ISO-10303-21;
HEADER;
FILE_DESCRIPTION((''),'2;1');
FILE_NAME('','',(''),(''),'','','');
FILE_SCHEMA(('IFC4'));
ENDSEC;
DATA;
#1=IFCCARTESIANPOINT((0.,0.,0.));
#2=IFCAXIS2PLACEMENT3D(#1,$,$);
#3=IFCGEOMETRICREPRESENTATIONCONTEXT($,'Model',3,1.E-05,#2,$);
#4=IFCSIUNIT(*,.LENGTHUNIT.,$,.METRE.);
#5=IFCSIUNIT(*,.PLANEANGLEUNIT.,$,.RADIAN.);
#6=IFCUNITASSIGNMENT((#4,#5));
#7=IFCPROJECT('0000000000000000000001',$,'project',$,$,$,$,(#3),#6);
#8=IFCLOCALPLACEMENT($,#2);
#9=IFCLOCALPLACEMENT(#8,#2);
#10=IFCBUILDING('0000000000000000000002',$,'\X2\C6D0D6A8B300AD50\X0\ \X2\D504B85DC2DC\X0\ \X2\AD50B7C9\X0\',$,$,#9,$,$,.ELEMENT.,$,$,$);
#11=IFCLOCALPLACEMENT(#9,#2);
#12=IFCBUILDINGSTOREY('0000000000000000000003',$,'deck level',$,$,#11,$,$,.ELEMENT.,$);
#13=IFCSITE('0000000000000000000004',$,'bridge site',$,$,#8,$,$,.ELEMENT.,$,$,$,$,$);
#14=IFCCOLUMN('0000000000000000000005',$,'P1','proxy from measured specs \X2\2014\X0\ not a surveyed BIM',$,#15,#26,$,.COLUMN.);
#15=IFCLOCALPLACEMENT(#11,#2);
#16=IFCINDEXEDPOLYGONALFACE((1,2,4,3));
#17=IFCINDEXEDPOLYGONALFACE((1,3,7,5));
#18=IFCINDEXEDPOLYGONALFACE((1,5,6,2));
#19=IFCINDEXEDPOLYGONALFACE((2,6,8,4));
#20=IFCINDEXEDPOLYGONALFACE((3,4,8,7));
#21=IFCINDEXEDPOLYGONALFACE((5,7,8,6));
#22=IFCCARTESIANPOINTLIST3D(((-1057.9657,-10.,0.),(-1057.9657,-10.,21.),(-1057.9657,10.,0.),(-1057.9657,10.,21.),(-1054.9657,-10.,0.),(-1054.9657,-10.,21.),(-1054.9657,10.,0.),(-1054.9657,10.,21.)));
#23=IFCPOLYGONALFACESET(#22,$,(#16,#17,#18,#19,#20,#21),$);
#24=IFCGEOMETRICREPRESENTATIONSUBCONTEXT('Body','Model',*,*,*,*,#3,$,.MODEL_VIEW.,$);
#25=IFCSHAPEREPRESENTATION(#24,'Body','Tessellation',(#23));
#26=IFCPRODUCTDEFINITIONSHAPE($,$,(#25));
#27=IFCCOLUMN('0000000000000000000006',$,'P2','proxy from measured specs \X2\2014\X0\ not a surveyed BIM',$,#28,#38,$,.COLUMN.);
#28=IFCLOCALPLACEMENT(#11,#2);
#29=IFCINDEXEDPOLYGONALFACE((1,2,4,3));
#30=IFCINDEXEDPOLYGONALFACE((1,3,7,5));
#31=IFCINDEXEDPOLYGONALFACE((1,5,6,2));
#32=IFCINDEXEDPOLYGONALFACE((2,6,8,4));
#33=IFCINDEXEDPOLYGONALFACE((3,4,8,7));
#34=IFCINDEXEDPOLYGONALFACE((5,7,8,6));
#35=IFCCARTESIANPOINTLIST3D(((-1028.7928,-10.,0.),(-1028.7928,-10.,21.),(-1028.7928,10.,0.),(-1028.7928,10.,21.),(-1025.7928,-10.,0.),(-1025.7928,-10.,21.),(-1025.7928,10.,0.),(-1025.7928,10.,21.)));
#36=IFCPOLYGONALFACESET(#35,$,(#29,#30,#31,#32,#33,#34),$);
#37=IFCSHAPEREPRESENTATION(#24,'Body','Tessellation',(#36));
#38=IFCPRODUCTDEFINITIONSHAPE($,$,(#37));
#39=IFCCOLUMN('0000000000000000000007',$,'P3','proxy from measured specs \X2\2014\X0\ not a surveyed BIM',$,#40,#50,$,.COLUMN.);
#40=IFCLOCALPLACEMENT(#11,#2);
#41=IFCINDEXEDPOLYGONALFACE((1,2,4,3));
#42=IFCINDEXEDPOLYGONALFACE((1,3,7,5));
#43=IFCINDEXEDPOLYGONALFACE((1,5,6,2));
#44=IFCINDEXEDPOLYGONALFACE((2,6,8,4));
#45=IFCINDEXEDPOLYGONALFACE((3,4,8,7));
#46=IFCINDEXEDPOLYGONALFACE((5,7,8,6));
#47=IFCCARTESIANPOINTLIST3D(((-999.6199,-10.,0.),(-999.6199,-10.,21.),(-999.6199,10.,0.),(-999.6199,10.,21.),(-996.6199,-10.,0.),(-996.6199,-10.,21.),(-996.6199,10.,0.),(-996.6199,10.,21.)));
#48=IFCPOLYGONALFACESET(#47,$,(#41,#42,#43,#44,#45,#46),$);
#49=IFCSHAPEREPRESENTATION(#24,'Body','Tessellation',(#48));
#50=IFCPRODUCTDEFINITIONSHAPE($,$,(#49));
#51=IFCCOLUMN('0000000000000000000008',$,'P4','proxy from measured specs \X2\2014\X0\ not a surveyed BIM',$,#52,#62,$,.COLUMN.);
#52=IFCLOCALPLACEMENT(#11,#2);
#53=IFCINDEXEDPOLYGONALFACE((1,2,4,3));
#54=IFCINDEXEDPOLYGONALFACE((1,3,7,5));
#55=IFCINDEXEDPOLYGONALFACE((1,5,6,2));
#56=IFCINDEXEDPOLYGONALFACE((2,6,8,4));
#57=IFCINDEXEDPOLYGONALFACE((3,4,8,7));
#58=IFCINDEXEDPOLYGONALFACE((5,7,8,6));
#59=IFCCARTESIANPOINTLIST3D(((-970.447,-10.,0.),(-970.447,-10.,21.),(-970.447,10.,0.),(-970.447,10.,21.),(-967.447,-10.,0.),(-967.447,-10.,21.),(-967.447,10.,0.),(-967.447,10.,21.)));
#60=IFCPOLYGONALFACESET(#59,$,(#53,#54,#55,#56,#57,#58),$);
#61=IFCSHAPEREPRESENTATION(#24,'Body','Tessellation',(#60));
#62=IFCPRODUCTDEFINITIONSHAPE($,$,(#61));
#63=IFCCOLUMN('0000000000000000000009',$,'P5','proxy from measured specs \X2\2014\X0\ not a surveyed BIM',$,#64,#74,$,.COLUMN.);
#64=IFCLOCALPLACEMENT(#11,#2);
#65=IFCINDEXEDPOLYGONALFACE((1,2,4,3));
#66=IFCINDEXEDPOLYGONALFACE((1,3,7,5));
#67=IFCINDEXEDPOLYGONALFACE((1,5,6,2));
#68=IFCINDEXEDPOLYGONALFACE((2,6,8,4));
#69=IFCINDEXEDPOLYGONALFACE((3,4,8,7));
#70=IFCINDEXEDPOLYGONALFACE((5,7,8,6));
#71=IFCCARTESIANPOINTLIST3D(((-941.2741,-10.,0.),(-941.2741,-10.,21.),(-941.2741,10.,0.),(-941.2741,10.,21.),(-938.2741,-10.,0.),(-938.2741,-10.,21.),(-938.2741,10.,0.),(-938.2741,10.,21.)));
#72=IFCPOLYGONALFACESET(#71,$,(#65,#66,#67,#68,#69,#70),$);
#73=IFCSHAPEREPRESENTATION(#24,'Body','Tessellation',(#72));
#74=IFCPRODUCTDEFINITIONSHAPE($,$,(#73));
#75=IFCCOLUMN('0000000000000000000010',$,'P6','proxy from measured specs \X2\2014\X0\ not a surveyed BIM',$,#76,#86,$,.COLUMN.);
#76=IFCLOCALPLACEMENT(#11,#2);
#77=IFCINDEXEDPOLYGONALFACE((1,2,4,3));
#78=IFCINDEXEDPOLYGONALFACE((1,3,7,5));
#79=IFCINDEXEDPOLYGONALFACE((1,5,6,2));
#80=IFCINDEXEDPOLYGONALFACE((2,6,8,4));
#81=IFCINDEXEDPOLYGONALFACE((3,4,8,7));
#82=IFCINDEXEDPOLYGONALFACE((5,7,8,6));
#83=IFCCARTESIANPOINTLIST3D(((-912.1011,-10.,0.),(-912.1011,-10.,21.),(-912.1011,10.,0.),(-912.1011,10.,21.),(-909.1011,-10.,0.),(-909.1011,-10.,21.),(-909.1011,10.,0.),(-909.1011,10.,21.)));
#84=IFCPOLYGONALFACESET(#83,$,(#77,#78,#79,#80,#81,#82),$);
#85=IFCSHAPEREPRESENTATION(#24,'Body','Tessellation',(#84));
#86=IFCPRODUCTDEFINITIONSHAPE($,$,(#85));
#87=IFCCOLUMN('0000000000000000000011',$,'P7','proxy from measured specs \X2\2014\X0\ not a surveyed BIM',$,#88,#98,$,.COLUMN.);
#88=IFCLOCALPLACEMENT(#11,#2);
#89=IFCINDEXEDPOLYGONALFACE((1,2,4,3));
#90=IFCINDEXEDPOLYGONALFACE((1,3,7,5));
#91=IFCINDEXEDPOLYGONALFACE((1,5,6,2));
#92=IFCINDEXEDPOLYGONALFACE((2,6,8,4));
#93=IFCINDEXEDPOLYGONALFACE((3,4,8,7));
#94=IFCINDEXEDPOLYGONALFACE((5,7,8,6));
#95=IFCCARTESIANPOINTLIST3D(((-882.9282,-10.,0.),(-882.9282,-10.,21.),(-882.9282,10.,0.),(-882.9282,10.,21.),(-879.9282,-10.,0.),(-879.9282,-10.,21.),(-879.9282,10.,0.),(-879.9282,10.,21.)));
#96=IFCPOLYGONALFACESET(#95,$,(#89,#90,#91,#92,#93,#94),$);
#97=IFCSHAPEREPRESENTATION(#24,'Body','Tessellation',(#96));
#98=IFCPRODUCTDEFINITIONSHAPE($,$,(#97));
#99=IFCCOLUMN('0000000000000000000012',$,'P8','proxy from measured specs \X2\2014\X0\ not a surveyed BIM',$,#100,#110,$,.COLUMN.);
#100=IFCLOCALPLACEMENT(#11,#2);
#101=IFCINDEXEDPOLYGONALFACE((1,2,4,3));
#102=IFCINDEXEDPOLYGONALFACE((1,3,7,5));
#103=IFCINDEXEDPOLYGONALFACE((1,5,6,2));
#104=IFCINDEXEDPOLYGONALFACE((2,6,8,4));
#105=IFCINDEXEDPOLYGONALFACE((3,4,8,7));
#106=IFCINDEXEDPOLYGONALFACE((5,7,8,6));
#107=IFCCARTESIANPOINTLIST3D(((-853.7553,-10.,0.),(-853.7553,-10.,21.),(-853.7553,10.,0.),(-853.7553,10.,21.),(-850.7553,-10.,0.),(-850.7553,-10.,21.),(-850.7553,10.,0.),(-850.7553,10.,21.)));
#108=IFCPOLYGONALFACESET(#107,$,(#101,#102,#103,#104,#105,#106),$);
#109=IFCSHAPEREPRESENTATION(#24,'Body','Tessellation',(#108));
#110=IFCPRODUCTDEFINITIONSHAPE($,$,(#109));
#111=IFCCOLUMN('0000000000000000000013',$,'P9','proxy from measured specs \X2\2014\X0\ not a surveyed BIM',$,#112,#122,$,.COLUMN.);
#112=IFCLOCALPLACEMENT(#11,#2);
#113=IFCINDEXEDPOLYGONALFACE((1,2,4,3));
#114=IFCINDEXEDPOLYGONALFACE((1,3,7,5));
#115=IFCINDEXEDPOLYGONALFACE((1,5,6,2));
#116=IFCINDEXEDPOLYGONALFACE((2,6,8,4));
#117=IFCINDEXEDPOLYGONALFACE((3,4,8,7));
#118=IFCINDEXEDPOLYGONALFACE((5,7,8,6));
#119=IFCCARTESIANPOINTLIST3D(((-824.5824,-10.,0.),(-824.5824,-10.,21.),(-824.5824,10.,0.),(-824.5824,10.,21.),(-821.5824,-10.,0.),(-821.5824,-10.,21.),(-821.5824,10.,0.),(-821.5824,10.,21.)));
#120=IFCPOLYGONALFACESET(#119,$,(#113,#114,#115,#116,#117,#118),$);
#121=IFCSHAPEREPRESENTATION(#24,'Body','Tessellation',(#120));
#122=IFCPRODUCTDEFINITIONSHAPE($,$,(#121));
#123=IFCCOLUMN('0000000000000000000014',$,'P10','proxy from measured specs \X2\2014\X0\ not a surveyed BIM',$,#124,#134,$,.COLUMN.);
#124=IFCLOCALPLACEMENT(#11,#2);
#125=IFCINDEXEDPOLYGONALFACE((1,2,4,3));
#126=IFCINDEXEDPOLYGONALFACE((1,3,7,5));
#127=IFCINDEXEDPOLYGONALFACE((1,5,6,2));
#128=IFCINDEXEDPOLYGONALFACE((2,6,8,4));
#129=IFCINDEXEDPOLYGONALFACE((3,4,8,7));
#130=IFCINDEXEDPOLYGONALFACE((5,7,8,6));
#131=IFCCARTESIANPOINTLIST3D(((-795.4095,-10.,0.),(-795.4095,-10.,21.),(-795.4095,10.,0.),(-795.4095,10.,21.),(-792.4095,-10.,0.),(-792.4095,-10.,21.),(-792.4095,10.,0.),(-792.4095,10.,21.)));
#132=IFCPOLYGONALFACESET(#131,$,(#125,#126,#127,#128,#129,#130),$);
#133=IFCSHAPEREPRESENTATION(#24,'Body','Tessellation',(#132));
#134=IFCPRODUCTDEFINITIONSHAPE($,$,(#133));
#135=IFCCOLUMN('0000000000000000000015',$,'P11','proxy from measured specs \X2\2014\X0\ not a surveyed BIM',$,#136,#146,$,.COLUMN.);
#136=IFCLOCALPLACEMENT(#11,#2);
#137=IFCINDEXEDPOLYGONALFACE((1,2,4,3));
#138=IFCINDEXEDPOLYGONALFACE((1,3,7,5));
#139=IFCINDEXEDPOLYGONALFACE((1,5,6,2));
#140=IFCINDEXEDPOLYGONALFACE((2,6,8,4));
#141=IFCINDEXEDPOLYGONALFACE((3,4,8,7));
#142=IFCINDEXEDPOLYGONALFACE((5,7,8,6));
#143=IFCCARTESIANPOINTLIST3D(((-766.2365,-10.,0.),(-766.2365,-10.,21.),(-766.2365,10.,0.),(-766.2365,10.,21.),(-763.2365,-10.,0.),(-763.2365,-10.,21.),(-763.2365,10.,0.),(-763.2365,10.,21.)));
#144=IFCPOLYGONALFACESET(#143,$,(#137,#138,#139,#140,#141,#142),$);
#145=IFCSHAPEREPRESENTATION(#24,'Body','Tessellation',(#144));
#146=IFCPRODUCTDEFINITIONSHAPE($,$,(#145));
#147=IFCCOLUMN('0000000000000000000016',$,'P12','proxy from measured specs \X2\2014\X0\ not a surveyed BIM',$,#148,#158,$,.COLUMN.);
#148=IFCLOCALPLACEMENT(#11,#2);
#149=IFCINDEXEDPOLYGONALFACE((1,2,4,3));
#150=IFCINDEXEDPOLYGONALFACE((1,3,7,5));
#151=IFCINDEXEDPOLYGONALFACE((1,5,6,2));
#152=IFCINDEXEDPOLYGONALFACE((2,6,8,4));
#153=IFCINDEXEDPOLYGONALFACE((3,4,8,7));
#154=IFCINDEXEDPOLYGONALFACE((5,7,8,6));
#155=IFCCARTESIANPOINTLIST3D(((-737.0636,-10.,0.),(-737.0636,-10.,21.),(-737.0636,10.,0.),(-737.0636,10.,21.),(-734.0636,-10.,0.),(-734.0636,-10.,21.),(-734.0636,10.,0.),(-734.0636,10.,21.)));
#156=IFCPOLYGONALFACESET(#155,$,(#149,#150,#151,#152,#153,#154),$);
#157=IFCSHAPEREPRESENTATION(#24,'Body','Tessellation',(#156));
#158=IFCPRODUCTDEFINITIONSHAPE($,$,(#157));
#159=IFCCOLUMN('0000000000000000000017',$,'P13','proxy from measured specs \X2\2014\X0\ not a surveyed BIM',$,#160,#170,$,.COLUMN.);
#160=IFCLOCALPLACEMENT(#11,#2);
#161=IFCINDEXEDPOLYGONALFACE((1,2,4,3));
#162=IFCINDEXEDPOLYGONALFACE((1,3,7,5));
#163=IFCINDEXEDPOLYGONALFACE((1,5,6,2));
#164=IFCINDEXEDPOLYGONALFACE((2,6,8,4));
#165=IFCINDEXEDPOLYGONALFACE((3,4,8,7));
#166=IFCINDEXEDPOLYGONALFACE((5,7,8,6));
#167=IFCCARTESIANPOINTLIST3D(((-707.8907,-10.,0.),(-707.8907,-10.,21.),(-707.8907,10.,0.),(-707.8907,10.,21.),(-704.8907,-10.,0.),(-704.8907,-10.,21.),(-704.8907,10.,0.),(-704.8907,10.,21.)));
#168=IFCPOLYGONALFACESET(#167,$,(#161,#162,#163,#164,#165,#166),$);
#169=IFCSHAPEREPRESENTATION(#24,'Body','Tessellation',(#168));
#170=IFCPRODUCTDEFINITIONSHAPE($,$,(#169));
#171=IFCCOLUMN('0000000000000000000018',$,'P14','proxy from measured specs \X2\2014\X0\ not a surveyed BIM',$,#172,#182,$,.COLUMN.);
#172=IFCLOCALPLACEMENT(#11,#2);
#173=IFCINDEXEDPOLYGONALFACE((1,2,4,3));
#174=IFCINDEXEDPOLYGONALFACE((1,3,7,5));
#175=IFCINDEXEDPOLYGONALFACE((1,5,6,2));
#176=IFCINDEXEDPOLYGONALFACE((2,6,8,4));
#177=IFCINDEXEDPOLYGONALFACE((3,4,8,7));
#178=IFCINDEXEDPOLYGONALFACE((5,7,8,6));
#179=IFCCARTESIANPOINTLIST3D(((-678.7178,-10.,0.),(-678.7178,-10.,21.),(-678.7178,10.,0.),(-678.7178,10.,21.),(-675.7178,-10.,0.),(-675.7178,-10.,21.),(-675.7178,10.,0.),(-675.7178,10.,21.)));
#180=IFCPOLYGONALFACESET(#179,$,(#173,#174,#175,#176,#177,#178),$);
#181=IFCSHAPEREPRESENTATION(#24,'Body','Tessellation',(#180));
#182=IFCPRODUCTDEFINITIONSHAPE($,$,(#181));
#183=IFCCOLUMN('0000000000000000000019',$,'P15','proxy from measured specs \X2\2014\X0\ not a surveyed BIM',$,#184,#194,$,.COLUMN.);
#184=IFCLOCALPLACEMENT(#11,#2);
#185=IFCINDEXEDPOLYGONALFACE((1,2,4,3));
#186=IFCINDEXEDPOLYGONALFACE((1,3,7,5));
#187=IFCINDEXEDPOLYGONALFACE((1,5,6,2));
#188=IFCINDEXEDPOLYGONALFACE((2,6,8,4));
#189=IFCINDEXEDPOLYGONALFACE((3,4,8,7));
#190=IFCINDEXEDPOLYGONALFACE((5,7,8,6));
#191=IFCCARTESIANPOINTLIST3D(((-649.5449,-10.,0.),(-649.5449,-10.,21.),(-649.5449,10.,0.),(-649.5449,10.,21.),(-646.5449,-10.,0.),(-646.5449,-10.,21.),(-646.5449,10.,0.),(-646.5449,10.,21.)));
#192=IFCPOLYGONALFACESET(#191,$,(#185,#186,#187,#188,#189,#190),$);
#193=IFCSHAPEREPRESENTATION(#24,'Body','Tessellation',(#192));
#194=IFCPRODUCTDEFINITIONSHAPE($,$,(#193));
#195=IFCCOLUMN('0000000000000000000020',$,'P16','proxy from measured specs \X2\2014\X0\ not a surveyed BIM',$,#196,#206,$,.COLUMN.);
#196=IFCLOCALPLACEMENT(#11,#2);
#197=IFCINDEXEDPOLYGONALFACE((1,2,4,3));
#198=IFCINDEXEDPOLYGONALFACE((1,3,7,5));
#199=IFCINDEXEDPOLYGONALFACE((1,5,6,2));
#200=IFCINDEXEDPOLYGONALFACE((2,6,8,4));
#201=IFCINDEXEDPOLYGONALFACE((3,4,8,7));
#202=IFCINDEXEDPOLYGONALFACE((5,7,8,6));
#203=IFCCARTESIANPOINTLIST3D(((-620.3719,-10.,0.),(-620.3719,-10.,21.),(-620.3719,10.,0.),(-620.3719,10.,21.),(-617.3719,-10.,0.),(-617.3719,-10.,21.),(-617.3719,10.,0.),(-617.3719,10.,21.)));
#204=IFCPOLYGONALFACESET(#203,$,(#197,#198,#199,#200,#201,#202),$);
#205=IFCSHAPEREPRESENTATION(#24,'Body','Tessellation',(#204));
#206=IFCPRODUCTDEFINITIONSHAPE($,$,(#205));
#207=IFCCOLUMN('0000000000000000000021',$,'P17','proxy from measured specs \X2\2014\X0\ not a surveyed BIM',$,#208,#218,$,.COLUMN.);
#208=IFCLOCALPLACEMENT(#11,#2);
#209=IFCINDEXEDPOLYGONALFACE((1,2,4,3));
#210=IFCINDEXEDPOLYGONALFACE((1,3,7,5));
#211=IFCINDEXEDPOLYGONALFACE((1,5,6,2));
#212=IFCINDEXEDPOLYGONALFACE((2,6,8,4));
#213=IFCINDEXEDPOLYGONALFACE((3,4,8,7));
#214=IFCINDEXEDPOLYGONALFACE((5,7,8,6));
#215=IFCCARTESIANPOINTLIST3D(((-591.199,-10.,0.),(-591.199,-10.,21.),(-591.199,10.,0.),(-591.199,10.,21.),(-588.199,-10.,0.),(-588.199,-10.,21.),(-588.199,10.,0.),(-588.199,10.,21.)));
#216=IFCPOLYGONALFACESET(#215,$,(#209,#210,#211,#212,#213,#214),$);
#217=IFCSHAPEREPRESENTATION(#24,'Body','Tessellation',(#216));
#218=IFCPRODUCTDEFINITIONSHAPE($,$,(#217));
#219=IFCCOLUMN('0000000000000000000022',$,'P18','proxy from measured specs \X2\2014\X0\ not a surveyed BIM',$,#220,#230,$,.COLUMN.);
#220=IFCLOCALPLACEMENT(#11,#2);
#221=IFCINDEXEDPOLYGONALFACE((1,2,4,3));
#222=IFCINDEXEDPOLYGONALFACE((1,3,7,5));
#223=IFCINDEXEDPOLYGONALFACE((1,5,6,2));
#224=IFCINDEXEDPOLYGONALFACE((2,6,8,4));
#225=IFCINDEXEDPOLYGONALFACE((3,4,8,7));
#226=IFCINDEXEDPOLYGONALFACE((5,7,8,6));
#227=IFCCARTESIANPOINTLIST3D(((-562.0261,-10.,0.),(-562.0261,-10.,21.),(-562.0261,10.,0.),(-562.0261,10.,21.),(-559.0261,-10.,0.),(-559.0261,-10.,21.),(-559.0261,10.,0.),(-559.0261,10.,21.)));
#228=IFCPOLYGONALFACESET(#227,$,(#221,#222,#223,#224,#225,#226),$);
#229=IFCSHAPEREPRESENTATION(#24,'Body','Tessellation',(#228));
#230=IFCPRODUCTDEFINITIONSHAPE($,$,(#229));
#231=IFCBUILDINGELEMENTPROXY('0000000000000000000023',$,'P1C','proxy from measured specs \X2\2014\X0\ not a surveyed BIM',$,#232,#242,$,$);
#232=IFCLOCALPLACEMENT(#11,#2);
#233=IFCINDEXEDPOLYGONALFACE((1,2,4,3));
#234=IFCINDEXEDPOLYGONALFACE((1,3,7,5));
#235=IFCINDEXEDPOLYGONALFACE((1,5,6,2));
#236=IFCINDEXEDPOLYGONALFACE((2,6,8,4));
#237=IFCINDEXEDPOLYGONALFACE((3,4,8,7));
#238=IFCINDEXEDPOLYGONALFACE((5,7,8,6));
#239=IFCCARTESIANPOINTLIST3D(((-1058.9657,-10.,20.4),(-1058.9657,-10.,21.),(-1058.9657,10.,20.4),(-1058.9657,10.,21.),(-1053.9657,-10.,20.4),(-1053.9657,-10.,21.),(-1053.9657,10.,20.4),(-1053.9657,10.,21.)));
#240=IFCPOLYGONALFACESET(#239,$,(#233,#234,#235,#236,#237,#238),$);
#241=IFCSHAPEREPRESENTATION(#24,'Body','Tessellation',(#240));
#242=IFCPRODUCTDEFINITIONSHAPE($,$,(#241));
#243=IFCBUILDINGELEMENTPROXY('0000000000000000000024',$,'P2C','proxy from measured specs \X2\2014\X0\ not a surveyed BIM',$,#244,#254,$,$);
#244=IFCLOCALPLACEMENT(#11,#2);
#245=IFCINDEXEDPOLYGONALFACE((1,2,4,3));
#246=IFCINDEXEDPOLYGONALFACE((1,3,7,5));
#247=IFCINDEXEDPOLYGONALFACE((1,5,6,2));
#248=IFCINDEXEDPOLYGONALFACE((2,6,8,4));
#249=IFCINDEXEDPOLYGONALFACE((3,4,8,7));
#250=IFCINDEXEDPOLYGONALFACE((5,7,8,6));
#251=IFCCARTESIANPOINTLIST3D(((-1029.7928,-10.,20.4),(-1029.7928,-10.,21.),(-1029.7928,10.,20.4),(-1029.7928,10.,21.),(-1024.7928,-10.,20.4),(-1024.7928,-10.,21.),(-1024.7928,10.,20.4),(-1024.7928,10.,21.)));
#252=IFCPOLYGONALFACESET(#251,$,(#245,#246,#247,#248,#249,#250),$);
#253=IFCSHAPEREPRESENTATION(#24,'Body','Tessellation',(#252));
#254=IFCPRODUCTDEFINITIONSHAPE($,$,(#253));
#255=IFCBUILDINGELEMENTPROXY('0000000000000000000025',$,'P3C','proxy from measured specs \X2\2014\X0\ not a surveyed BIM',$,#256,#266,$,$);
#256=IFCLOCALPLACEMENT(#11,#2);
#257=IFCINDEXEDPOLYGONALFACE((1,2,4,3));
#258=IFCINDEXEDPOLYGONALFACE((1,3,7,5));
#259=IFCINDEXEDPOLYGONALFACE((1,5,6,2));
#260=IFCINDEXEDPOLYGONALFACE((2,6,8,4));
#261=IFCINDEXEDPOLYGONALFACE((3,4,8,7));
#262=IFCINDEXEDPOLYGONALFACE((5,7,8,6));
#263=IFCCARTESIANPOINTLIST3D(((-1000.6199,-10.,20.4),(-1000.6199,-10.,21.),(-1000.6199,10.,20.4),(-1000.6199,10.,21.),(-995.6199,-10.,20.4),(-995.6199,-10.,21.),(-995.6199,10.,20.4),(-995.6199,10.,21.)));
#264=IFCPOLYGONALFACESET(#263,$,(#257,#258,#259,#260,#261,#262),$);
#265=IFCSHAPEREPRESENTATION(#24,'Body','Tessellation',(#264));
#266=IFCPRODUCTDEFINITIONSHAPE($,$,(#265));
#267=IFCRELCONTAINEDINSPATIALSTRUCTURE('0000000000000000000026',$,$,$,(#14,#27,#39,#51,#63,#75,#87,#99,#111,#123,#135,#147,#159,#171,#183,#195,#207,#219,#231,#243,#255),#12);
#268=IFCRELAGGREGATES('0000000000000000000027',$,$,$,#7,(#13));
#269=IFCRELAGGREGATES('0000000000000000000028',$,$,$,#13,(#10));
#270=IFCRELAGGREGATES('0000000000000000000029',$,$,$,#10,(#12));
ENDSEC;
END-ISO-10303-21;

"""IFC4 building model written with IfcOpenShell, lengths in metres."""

from ifc_helpers import new_model, si_unit, frame, origin, origin_2d, place, context, subcontext, project, spatial, rectangle, extrude, element, save


model = new_model("IFC4")

# Units and contexts
model_context = context("Model", 3, precision=1e-05, world=origin())
body_context = subcontext(model_context, "Body", "Model", "MODEL_VIEW")
ifc_project = project(units=[si_unit("LENGTHUNIT", "METRE"), si_unit("PLANEANGLEUNIT", "RADIAN")], contexts=[model_context])

# Site, building, storey
site_placement = place(None, origin())
site = spatial("IfcSite", under=ifc_project, at=site_placement, Name="bridge site", CompositionType="ELEMENT")
building_placement = place(site_placement, origin())
building = spatial("IfcBuilding", under=site, at=building_placement, Name="원효대교 프록시 교량", CompositionType="ELEMENT")
storey_placement = place(building_placement, origin())
storey = spatial("IfcBuildingStorey", under=building, at=storey_placement, Name="deck level", CompositionType="ELEMENT")

# Columns
for number, where, name in (
    (1, (-1056.4657, 0.0, 0.0), "P1"),
    (2, (-1027.2928, 0.0, 0.0), "P2"),
    (3, (-998.1199, 0.0, 0.0), "P3"),
    (4, (-968.947, 0.0, 0.0), "P4"),
    (5, (-939.7741, 0.0, 0.0), "P5"),
    (6, (-910.6011, 0.0, 0.0), "P6"),
    (7, (-881.4282, 0.0, 0.0), "P7"),
    (8, (-852.2553, 0.0, 0.0), "P8"),
    (9, (-823.0824, 0.0, 0.0), "P9"),
    (10, (-793.9095, 0.0, 0.0), "P10"),
    (11, (-764.7365, 0.0, 0.0), "P11"),
    (12, (-735.5636, 0.0, 0.0), "P12"),
    (13, (-706.3907, 0.0, 0.0), "P13"),
    (14, (-677.2178, 0.0, 0.0), "P14"),
    (15, (-648.0449, 0.0, 0.0), "P15"),
    (16, (-618.8719, 0.0, 0.0), "P16"),
    (17, (-589.699, 0.0, 0.0), "P17"),
    (18, (-560.5261, 0.0, 0.0), "P18"),
):
    element("IfcColumn", number, at=place(storey_placement, frame(where)), inside=storey, Name=name, Description="proxy from measured specs — not a surveyed BIM", PredefinedType="COLUMN", context=body_context, shape_type="SweptSolid", body=[
        extrude(rectangle(XDim=3.0, YDim=20.0, at=origin_2d()), origin(), (0.0, 0.0, 1.0), 21.0),
    ])

# Building element proxies
for number, where, name in (
    (19, (-1056.4657, 0.0, 20.4), "P1C"),
    (20, (-1027.2928, 0.0, 20.4), "P2C"),
    (21, (-998.1199, 0.0, 20.4), "P3C"),
):
    element("IfcBuildingElementProxy", number, at=place(storey_placement, frame(where)), inside=storey, Name=name, Description="proxy from measured specs — not a surveyed BIM", context=body_context, shape_type="SweptSolid", body=[
        extrude(rectangle(XDim=5.0, YDim=20.0, at=origin_2d()), origin(), (0.0, 0.0, 1.0), 0.6),
    ])

save(model, "model.ifc")
